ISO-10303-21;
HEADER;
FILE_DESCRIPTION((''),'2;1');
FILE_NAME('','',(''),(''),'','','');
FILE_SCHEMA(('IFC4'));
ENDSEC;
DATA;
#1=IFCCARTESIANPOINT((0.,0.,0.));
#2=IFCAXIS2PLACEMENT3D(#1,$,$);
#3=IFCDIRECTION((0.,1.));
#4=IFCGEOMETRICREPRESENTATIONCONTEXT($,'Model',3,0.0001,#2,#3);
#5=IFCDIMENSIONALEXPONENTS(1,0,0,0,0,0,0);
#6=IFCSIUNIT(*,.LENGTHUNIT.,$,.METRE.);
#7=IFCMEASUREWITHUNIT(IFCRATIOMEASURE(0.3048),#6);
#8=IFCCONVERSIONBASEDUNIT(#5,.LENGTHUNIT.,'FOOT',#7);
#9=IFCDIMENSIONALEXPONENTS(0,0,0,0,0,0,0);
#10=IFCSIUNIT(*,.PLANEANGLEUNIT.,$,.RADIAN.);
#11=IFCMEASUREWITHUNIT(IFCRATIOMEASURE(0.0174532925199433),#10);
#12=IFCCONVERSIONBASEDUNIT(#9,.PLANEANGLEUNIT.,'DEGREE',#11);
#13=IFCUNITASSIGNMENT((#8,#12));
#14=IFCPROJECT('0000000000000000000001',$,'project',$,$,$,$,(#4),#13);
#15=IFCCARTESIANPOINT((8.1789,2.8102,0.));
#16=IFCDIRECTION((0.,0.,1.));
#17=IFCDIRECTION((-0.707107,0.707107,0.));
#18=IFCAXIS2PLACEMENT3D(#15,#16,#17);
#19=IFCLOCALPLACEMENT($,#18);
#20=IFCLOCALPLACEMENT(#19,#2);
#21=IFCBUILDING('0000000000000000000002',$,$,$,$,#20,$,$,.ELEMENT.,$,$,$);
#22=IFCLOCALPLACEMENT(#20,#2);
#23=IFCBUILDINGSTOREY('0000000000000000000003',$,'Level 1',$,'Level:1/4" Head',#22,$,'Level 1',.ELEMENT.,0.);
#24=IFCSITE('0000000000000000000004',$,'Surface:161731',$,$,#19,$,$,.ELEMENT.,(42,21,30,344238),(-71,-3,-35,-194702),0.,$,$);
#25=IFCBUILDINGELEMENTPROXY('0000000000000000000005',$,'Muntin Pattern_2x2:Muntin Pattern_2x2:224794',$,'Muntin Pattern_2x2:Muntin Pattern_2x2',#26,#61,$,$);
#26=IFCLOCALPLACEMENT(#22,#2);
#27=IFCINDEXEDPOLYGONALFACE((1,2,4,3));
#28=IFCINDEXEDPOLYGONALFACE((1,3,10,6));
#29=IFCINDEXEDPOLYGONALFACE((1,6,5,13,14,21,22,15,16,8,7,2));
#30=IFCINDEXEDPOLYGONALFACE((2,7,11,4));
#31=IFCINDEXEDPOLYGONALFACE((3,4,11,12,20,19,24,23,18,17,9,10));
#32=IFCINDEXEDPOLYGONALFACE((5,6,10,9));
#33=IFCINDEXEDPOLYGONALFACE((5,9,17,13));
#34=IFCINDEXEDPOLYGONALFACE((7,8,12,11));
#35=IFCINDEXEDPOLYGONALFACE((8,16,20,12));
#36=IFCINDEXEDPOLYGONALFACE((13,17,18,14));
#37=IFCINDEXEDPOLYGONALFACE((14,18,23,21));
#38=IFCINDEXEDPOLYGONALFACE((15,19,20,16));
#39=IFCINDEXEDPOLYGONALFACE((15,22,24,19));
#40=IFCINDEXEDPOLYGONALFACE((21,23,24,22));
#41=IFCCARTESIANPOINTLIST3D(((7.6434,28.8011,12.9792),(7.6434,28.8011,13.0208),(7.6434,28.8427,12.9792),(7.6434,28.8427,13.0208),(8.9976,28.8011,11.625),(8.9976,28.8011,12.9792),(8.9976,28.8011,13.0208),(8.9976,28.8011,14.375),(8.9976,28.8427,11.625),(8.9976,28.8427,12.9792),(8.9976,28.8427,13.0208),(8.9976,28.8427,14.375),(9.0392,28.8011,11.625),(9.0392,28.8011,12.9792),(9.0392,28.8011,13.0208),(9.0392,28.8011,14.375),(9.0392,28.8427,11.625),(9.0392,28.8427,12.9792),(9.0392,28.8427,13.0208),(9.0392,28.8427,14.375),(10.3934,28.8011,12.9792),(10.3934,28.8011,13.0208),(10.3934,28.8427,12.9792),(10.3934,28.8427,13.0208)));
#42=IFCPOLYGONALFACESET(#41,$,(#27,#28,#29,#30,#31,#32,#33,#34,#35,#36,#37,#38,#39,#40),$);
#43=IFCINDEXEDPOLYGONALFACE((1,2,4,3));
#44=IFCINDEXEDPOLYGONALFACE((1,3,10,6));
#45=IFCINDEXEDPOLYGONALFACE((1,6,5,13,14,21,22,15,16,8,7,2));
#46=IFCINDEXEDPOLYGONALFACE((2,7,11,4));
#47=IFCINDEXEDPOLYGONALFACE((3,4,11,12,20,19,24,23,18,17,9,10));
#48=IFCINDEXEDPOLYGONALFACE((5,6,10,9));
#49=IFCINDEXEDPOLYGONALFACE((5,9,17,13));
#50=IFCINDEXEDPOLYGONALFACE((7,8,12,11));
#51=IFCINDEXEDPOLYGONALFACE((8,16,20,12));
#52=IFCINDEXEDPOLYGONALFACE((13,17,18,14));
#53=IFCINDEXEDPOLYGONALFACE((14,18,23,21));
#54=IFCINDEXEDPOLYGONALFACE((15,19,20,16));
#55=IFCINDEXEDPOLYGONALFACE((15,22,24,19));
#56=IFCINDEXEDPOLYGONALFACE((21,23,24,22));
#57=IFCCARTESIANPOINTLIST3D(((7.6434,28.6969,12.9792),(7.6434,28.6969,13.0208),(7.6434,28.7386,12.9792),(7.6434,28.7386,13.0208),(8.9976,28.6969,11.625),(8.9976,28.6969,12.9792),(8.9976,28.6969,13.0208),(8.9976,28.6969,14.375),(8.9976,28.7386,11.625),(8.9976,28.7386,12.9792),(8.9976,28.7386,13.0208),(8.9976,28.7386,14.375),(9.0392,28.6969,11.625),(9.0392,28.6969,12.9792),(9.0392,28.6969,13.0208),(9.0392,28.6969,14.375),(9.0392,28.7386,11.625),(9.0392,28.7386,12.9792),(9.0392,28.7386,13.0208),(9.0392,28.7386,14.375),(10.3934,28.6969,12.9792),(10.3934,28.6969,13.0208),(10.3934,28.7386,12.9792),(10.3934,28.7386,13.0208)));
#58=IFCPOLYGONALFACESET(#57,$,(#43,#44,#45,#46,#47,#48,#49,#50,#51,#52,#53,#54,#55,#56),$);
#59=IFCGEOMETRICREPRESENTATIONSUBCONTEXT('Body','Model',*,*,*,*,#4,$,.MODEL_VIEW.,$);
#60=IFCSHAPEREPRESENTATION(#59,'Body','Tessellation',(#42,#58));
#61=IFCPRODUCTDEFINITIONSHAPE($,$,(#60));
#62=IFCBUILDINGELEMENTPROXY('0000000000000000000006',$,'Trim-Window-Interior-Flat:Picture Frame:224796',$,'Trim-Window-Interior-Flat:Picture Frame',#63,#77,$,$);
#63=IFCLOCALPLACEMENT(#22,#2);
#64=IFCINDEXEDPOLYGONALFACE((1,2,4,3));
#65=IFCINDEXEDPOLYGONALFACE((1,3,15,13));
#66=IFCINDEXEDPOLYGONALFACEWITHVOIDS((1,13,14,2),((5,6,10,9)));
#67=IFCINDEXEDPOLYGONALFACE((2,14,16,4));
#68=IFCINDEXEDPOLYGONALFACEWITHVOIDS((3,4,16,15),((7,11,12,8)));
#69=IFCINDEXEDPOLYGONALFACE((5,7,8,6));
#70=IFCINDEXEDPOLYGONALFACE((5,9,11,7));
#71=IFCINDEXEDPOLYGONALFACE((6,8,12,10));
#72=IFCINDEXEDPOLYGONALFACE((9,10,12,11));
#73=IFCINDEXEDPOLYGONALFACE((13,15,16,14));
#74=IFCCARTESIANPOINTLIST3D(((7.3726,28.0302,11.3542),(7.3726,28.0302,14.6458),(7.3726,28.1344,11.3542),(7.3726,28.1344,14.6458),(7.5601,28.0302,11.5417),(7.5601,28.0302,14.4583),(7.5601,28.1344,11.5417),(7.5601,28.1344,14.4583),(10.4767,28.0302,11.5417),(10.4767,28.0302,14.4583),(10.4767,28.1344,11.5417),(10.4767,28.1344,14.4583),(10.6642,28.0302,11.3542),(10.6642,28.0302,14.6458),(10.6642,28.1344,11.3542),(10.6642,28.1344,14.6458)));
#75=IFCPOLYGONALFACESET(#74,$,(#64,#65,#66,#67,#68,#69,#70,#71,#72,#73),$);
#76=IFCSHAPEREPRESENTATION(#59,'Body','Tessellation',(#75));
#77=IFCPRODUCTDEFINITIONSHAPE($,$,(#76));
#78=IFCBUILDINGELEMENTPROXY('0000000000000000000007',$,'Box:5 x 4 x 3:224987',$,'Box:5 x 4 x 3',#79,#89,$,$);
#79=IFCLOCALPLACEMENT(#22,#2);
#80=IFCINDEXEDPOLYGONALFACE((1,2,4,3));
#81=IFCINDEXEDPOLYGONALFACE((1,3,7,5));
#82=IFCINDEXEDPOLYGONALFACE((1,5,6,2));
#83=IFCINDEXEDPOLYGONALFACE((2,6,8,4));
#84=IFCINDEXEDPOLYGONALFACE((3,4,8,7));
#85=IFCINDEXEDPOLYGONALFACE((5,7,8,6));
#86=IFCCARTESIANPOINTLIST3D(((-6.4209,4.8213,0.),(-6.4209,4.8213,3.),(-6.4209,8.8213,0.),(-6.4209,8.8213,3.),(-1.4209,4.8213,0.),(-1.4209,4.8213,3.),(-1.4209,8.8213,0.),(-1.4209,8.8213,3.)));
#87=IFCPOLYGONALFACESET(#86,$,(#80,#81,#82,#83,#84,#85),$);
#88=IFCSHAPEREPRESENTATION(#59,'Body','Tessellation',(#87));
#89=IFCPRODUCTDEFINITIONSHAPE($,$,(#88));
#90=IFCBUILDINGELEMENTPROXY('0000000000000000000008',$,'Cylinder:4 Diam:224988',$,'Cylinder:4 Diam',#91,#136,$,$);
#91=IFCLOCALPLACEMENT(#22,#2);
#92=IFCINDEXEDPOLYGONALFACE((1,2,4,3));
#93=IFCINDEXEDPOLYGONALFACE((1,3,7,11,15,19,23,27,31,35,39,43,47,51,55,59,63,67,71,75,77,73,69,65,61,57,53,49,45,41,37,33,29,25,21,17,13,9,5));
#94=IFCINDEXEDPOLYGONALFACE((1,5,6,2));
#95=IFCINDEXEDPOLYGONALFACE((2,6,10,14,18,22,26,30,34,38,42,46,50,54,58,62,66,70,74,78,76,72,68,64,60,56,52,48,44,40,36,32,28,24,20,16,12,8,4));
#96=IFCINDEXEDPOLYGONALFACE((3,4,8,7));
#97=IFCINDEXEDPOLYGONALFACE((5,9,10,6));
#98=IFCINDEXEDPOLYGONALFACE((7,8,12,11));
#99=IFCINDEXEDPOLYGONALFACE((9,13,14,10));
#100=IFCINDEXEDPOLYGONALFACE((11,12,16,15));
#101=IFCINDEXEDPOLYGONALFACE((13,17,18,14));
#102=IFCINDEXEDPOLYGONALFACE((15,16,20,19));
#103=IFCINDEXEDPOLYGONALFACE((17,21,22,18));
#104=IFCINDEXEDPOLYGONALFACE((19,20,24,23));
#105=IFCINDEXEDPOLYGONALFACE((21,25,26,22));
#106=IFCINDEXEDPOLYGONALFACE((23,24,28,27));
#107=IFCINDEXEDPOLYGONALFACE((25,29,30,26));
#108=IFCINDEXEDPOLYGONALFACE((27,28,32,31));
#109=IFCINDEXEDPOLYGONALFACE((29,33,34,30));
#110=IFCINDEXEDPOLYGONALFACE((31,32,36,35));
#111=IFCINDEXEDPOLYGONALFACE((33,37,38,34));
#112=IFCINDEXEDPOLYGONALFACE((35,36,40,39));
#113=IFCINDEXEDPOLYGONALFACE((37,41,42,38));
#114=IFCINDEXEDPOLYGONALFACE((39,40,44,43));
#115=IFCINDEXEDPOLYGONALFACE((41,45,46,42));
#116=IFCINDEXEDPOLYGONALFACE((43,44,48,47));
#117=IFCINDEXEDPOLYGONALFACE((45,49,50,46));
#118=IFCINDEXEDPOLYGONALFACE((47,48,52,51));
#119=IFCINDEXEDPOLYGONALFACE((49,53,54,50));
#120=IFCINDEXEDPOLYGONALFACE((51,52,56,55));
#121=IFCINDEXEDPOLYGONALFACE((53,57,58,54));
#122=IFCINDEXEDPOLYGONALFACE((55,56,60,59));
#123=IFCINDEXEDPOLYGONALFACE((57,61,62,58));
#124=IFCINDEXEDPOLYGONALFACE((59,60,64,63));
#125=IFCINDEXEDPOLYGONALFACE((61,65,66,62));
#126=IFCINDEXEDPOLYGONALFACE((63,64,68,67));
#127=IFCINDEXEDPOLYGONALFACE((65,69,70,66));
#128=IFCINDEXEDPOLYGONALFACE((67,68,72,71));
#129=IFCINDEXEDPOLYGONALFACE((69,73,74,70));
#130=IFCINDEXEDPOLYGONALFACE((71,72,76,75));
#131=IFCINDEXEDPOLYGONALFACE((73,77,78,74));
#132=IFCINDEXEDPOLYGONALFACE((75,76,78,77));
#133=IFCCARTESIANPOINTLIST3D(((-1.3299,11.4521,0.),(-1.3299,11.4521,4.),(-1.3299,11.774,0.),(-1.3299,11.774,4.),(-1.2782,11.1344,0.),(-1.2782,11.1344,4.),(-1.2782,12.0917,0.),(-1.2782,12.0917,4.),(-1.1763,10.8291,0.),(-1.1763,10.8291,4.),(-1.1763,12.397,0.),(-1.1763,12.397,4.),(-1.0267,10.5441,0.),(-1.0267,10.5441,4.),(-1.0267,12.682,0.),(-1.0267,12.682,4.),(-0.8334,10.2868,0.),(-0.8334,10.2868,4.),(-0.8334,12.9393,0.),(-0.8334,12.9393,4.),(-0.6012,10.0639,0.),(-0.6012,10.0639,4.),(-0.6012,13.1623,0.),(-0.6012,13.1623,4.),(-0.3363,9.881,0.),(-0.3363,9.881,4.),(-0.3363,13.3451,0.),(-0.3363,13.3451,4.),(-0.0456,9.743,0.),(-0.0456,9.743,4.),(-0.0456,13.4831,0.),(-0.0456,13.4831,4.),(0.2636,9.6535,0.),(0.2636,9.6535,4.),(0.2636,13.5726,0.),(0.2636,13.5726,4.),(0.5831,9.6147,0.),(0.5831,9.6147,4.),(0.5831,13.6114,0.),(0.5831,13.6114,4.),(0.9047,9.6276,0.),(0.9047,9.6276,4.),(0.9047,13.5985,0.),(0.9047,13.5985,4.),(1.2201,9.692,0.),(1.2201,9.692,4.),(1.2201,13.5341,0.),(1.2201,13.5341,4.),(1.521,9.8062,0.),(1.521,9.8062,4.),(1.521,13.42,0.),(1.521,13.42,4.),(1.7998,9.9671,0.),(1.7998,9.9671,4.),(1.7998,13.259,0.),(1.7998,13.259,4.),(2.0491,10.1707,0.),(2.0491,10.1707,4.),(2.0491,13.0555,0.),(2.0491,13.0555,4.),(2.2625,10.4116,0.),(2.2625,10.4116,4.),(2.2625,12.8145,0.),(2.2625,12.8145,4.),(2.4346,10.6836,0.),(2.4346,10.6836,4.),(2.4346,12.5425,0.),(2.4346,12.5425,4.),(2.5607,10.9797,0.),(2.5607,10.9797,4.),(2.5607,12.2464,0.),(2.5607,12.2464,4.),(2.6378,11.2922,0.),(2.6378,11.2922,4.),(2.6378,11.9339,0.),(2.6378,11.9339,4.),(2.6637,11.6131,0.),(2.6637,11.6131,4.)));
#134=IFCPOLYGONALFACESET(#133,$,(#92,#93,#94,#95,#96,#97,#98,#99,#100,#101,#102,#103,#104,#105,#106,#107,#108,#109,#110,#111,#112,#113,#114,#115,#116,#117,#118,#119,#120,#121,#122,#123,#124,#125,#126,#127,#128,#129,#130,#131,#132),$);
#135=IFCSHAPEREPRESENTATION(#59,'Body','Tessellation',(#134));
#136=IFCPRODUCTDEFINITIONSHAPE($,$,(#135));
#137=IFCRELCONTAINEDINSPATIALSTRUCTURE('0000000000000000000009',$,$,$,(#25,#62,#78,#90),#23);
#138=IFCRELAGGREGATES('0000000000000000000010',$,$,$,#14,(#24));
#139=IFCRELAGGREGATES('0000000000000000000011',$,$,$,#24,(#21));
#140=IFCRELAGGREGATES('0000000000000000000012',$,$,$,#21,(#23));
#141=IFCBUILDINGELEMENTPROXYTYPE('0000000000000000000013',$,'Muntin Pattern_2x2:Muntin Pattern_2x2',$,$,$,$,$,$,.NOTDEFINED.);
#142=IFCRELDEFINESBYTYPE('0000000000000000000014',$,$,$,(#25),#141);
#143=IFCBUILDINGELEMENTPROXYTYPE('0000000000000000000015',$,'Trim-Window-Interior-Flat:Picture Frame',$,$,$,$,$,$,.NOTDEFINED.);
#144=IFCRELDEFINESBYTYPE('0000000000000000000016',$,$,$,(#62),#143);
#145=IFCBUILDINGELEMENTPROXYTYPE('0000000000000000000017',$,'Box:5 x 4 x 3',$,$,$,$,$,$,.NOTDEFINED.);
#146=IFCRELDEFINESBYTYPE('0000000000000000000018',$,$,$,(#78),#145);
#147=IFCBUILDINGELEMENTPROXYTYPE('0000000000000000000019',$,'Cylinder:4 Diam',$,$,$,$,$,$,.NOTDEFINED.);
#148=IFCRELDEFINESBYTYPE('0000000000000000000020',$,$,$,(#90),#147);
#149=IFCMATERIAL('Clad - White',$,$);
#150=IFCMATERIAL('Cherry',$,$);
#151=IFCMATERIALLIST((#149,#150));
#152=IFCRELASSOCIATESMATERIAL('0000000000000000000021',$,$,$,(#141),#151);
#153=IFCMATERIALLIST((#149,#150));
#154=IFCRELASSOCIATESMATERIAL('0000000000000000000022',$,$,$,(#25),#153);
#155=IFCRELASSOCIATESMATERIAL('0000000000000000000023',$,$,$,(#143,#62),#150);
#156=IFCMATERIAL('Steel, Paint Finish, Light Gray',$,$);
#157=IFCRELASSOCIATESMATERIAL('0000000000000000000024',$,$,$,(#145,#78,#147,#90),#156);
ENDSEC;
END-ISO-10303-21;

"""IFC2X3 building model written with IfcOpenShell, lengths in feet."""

from ifc_helpers import new_model, entity, si_unit, converted_unit, direction, frame, frame_2d, origin, origin_2d_with_axis, place, context, subcontext, project, spatial, polyline, rectangle, circle, outline, extrude, source, transform, mapped, material, material_list, type_object, type_shapes, element, save


model = new_model("IFC2X3")

# Units and contexts
model_context = context("Model", 3, precision=0.0001, world=origin(), true_north=direction((0.0, 1.0)))
body_context = subcontext(model_context, "Body", "Model", "MODEL_VIEW")
ifc_project = project(units=[converted_unit("LENGTHUNIT", "FOOT", entity("IfcRatioMeasure", 0.3048), si_unit("LENGTHUNIT", "METRE"), dimensions=[1, 0, 0, 0, 0, 0, 0]), converted_unit("PLANEANGLEUNIT", "DEGREE", entity("IfcRatioMeasure", 0.0174532925199433), si_unit("PLANEANGLEUNIT", "RADIAN"), dimensions=[0, 0, 0, 0, 0, 0, 0])], contexts=[model_context])

# Site, building, storey
site_placement = place(None, frame((8.1789, 2.8102, 0.0), z_axis=(0.0, 0.0, 1.0), x_axis=(-0.707107, 0.707107, 0.0)))
site = spatial("IfcSite", under=ifc_project, at=site_placement, Name="Surface:161731", CompositionType="ELEMENT", RefLatitude=(42, 21, 30, 344238), RefLongitude=(-71, -3, -35, -194702), RefElevation=0.0)
building_placement = place(site_placement, origin())
building = spatial("IfcBuilding", under=site, at=building_placement, CompositionType="ELEMENT")
storey_placement = place(building_placement, origin())
storey = spatial("IfcBuildingStorey", under=building, at=storey_placement, Name="Level 1", ObjectType="Level:1/4\" Head", LongName="Level 1", CompositionType="ELEMENT", Elevation=0.0)

# Building element proxies
ifc_material_1 = material(Name="Cherry")
ifc_material_2 = material(Name="Clad - White")
ifc_material_list_1 = material_list([ifc_material_2, ifc_material_1])
ifc_material_list_2 = material_list([ifc_material_2, ifc_material_1])
building_element_proxy_type_1 = type_object("IfcBuildingElementProxyType", Name="Muntin Pattern_2x2:Muntin Pattern_2x2", PredefinedType="NOTDEFINED", material=ifc_material_list_2)
shared_shape_1 = source(origin(), body_context, "Body", "SweptSolid", [
    extrude(outline(polyline([(0.0208, -0.0208), (1.375, -0.0208), (1.375, 0.0208), (0.0208, 0.0208), (0.0208, 1.375), (-0.0208, 1.375), (-0.0208, 0.0208), (-1.375, 0.0208), (-1.375, -0.0208), (-0.0208, -0.0208), (-0.0208, -1.375), (0.0208, -1.375), (0.0208, -0.0208)])), frame((0.0, -0.0729, 1.375), z_axis=(0.0, 1.0, 0.0), x_axis=(0.0, 0.0, 1.0)), (0.0, 0.0, 1.0), 0.0417),
    extrude(outline(polyline([(0.0208, -0.0208), (1.375, -0.0208), (1.375, 0.0208), (0.0208, 0.0208), (0.0208, 1.375), (-0.0208, 1.375), (-0.0208, 0.0208), (-1.375, 0.0208), (-1.375, -0.0208), (-0.0208, -0.0208), (-0.0208, -1.375), (0.0208, -1.375), (0.0208, -0.0208)])), frame((0.0, 0.0313, 1.375), z_axis=(0.0, 1.0, 0.0), x_axis=(0.0, 0.0, 1.0)), (0.0, 0.0, 1.0), 0.0417),
])
type_shapes(building_element_proxy_type_1, [shared_shape_1])
proxy_1_placement = place(storey_placement, frame((9.0184, 28.7698, 11.625), z_axis=(0.0, 0.0, 1.0), x_axis=(-1.0, 0.0, 0.0)))
element("IfcBuildingElementProxy", 1, at=proxy_1_placement, inside=storey, type_object=building_element_proxy_type_1, material=ifc_material_list_1, Name="Muntin Pattern_2x2:Muntin Pattern_2x2:224794", ObjectType="Muntin Pattern_2x2:Muntin Pattern_2x2", context=body_context, shape_type="MappedRepresentation", body=[
    mapped(shared_shape_1, transform((0.0, 0.0, 0.0), scale=1.0)),
])
building_element_proxy_type_2 = type_object("IfcBuildingElementProxyType", Name="Trim-Window-Interior-Flat:Picture Frame", PredefinedType="NOTDEFINED", material=ifc_material_1)
shared_shape_2 = source(origin(), body_context, "Body", "SweptSolid", [
    extrude(outline(polyline([(-1.6458, -1.6458), (1.6458, -1.6458), (1.6458, 1.6458), (-1.6458, 1.6458), (-1.6458, -1.6458)]), holes=[polyline([(-1.4583, -1.4583), (-1.4583, 1.4583), (1.4583, 1.4583), (1.4583, -1.4583), (-1.4583, -1.4583)])]), frame((0.0, -1.5, 0.0), z_axis=(0.0, 0.0, 1.0), x_axis=(-1.0, 0.0, 0.0)), (0.0, 0.0, 1.0), 0.1042),
])
type_shapes(building_element_proxy_type_2, [shared_shape_2])
proxy_2_placement = place(storey_placement, frame((9.0184, 28.1344, 14.5), z_axis=(0.0, -1.0, 0.0), x_axis=(1.0, 0.0, 0.0)))
element("IfcBuildingElementProxy", 2, at=proxy_2_placement, inside=storey, type_object=building_element_proxy_type_2, material=ifc_material_1, Name="Trim-Window-Interior-Flat:Picture Frame:224796", ObjectType="Trim-Window-Interior-Flat:Picture Frame", context=body_context, shape_type="MappedRepresentation", body=[
    mapped(shared_shape_2, transform((0.0, 0.0, 0.0), scale=1.0)),
])
ifc_material_3 = material(Name="Steel, Paint Finish, Light Gray")
building_element_proxy_type_3 = type_object("IfcBuildingElementProxyType", Name="Box:5 x 4 x 3", PredefinedType="NOTDEFINED", material=ifc_material_3)
shared_shape_3 = source(origin(), body_context, "Body", "SweptSolid", [
    extrude(rectangle(XDim=5.0, YDim=4.0, at=origin_2d_with_axis()), frame((0.0, 0.0, 0.0), z_axis=(0.0, 0.0, 1.0), x_axis=(-1.0, 0.0, 0.0)), (0.0, 0.0, 1.0), 3.0),
])
type_shapes(building_element_proxy_type_3, [shared_shape_3])
proxy_3_placement = place(storey_placement, frame((-3.9209, 6.8213, 0.0), z_axis=(0.0, 0.0, 1.0), x_axis=(-1.0, 0.0, 0.0)))
element("IfcBuildingElementProxy", 3, at=proxy_3_placement, inside=storey, type_object=building_element_proxy_type_3, material=ifc_material_3, Name="Box:5 x 4 x 3:224987", ObjectType="Box:5 x 4 x 3", context=body_context, shape_type="MappedRepresentation", body=[
    mapped(shared_shape_3, transform((0.0, 0.0, 0.0), scale=1.0)),
])
building_element_proxy_type_4 = type_object("IfcBuildingElementProxyType", Name="Cylinder:4 Diam", PredefinedType="NOTDEFINED", material=ifc_material_3)
shared_shape_4 = source(origin(), body_context, "Body", "SweptSolid", [
    extrude(circle(Radius=2.0, at=frame_2d((0.0, 0.0), x_axis=(1.0, 0.0))), origin(), (0.0, 0.0, 1.0), 4.0),
])
type_shapes(building_element_proxy_type_4, [shared_shape_4])
proxy_4_placement = place(storey_placement, frame((0.6637, 11.6131, 0.0)))
element("IfcBuildingElementProxy", 4, at=proxy_4_placement, inside=storey, type_object=building_element_proxy_type_4, material=ifc_material_3, Name="Cylinder:4 Diam:224988", ObjectType="Cylinder:4 Diam", context=body_context, shape_type="MappedRepresentation", body=[
    mapped(shared_shape_4, transform((0.0, 0.0, 0.0), scale=1.0)),
])

save(model, "model.ifc")
